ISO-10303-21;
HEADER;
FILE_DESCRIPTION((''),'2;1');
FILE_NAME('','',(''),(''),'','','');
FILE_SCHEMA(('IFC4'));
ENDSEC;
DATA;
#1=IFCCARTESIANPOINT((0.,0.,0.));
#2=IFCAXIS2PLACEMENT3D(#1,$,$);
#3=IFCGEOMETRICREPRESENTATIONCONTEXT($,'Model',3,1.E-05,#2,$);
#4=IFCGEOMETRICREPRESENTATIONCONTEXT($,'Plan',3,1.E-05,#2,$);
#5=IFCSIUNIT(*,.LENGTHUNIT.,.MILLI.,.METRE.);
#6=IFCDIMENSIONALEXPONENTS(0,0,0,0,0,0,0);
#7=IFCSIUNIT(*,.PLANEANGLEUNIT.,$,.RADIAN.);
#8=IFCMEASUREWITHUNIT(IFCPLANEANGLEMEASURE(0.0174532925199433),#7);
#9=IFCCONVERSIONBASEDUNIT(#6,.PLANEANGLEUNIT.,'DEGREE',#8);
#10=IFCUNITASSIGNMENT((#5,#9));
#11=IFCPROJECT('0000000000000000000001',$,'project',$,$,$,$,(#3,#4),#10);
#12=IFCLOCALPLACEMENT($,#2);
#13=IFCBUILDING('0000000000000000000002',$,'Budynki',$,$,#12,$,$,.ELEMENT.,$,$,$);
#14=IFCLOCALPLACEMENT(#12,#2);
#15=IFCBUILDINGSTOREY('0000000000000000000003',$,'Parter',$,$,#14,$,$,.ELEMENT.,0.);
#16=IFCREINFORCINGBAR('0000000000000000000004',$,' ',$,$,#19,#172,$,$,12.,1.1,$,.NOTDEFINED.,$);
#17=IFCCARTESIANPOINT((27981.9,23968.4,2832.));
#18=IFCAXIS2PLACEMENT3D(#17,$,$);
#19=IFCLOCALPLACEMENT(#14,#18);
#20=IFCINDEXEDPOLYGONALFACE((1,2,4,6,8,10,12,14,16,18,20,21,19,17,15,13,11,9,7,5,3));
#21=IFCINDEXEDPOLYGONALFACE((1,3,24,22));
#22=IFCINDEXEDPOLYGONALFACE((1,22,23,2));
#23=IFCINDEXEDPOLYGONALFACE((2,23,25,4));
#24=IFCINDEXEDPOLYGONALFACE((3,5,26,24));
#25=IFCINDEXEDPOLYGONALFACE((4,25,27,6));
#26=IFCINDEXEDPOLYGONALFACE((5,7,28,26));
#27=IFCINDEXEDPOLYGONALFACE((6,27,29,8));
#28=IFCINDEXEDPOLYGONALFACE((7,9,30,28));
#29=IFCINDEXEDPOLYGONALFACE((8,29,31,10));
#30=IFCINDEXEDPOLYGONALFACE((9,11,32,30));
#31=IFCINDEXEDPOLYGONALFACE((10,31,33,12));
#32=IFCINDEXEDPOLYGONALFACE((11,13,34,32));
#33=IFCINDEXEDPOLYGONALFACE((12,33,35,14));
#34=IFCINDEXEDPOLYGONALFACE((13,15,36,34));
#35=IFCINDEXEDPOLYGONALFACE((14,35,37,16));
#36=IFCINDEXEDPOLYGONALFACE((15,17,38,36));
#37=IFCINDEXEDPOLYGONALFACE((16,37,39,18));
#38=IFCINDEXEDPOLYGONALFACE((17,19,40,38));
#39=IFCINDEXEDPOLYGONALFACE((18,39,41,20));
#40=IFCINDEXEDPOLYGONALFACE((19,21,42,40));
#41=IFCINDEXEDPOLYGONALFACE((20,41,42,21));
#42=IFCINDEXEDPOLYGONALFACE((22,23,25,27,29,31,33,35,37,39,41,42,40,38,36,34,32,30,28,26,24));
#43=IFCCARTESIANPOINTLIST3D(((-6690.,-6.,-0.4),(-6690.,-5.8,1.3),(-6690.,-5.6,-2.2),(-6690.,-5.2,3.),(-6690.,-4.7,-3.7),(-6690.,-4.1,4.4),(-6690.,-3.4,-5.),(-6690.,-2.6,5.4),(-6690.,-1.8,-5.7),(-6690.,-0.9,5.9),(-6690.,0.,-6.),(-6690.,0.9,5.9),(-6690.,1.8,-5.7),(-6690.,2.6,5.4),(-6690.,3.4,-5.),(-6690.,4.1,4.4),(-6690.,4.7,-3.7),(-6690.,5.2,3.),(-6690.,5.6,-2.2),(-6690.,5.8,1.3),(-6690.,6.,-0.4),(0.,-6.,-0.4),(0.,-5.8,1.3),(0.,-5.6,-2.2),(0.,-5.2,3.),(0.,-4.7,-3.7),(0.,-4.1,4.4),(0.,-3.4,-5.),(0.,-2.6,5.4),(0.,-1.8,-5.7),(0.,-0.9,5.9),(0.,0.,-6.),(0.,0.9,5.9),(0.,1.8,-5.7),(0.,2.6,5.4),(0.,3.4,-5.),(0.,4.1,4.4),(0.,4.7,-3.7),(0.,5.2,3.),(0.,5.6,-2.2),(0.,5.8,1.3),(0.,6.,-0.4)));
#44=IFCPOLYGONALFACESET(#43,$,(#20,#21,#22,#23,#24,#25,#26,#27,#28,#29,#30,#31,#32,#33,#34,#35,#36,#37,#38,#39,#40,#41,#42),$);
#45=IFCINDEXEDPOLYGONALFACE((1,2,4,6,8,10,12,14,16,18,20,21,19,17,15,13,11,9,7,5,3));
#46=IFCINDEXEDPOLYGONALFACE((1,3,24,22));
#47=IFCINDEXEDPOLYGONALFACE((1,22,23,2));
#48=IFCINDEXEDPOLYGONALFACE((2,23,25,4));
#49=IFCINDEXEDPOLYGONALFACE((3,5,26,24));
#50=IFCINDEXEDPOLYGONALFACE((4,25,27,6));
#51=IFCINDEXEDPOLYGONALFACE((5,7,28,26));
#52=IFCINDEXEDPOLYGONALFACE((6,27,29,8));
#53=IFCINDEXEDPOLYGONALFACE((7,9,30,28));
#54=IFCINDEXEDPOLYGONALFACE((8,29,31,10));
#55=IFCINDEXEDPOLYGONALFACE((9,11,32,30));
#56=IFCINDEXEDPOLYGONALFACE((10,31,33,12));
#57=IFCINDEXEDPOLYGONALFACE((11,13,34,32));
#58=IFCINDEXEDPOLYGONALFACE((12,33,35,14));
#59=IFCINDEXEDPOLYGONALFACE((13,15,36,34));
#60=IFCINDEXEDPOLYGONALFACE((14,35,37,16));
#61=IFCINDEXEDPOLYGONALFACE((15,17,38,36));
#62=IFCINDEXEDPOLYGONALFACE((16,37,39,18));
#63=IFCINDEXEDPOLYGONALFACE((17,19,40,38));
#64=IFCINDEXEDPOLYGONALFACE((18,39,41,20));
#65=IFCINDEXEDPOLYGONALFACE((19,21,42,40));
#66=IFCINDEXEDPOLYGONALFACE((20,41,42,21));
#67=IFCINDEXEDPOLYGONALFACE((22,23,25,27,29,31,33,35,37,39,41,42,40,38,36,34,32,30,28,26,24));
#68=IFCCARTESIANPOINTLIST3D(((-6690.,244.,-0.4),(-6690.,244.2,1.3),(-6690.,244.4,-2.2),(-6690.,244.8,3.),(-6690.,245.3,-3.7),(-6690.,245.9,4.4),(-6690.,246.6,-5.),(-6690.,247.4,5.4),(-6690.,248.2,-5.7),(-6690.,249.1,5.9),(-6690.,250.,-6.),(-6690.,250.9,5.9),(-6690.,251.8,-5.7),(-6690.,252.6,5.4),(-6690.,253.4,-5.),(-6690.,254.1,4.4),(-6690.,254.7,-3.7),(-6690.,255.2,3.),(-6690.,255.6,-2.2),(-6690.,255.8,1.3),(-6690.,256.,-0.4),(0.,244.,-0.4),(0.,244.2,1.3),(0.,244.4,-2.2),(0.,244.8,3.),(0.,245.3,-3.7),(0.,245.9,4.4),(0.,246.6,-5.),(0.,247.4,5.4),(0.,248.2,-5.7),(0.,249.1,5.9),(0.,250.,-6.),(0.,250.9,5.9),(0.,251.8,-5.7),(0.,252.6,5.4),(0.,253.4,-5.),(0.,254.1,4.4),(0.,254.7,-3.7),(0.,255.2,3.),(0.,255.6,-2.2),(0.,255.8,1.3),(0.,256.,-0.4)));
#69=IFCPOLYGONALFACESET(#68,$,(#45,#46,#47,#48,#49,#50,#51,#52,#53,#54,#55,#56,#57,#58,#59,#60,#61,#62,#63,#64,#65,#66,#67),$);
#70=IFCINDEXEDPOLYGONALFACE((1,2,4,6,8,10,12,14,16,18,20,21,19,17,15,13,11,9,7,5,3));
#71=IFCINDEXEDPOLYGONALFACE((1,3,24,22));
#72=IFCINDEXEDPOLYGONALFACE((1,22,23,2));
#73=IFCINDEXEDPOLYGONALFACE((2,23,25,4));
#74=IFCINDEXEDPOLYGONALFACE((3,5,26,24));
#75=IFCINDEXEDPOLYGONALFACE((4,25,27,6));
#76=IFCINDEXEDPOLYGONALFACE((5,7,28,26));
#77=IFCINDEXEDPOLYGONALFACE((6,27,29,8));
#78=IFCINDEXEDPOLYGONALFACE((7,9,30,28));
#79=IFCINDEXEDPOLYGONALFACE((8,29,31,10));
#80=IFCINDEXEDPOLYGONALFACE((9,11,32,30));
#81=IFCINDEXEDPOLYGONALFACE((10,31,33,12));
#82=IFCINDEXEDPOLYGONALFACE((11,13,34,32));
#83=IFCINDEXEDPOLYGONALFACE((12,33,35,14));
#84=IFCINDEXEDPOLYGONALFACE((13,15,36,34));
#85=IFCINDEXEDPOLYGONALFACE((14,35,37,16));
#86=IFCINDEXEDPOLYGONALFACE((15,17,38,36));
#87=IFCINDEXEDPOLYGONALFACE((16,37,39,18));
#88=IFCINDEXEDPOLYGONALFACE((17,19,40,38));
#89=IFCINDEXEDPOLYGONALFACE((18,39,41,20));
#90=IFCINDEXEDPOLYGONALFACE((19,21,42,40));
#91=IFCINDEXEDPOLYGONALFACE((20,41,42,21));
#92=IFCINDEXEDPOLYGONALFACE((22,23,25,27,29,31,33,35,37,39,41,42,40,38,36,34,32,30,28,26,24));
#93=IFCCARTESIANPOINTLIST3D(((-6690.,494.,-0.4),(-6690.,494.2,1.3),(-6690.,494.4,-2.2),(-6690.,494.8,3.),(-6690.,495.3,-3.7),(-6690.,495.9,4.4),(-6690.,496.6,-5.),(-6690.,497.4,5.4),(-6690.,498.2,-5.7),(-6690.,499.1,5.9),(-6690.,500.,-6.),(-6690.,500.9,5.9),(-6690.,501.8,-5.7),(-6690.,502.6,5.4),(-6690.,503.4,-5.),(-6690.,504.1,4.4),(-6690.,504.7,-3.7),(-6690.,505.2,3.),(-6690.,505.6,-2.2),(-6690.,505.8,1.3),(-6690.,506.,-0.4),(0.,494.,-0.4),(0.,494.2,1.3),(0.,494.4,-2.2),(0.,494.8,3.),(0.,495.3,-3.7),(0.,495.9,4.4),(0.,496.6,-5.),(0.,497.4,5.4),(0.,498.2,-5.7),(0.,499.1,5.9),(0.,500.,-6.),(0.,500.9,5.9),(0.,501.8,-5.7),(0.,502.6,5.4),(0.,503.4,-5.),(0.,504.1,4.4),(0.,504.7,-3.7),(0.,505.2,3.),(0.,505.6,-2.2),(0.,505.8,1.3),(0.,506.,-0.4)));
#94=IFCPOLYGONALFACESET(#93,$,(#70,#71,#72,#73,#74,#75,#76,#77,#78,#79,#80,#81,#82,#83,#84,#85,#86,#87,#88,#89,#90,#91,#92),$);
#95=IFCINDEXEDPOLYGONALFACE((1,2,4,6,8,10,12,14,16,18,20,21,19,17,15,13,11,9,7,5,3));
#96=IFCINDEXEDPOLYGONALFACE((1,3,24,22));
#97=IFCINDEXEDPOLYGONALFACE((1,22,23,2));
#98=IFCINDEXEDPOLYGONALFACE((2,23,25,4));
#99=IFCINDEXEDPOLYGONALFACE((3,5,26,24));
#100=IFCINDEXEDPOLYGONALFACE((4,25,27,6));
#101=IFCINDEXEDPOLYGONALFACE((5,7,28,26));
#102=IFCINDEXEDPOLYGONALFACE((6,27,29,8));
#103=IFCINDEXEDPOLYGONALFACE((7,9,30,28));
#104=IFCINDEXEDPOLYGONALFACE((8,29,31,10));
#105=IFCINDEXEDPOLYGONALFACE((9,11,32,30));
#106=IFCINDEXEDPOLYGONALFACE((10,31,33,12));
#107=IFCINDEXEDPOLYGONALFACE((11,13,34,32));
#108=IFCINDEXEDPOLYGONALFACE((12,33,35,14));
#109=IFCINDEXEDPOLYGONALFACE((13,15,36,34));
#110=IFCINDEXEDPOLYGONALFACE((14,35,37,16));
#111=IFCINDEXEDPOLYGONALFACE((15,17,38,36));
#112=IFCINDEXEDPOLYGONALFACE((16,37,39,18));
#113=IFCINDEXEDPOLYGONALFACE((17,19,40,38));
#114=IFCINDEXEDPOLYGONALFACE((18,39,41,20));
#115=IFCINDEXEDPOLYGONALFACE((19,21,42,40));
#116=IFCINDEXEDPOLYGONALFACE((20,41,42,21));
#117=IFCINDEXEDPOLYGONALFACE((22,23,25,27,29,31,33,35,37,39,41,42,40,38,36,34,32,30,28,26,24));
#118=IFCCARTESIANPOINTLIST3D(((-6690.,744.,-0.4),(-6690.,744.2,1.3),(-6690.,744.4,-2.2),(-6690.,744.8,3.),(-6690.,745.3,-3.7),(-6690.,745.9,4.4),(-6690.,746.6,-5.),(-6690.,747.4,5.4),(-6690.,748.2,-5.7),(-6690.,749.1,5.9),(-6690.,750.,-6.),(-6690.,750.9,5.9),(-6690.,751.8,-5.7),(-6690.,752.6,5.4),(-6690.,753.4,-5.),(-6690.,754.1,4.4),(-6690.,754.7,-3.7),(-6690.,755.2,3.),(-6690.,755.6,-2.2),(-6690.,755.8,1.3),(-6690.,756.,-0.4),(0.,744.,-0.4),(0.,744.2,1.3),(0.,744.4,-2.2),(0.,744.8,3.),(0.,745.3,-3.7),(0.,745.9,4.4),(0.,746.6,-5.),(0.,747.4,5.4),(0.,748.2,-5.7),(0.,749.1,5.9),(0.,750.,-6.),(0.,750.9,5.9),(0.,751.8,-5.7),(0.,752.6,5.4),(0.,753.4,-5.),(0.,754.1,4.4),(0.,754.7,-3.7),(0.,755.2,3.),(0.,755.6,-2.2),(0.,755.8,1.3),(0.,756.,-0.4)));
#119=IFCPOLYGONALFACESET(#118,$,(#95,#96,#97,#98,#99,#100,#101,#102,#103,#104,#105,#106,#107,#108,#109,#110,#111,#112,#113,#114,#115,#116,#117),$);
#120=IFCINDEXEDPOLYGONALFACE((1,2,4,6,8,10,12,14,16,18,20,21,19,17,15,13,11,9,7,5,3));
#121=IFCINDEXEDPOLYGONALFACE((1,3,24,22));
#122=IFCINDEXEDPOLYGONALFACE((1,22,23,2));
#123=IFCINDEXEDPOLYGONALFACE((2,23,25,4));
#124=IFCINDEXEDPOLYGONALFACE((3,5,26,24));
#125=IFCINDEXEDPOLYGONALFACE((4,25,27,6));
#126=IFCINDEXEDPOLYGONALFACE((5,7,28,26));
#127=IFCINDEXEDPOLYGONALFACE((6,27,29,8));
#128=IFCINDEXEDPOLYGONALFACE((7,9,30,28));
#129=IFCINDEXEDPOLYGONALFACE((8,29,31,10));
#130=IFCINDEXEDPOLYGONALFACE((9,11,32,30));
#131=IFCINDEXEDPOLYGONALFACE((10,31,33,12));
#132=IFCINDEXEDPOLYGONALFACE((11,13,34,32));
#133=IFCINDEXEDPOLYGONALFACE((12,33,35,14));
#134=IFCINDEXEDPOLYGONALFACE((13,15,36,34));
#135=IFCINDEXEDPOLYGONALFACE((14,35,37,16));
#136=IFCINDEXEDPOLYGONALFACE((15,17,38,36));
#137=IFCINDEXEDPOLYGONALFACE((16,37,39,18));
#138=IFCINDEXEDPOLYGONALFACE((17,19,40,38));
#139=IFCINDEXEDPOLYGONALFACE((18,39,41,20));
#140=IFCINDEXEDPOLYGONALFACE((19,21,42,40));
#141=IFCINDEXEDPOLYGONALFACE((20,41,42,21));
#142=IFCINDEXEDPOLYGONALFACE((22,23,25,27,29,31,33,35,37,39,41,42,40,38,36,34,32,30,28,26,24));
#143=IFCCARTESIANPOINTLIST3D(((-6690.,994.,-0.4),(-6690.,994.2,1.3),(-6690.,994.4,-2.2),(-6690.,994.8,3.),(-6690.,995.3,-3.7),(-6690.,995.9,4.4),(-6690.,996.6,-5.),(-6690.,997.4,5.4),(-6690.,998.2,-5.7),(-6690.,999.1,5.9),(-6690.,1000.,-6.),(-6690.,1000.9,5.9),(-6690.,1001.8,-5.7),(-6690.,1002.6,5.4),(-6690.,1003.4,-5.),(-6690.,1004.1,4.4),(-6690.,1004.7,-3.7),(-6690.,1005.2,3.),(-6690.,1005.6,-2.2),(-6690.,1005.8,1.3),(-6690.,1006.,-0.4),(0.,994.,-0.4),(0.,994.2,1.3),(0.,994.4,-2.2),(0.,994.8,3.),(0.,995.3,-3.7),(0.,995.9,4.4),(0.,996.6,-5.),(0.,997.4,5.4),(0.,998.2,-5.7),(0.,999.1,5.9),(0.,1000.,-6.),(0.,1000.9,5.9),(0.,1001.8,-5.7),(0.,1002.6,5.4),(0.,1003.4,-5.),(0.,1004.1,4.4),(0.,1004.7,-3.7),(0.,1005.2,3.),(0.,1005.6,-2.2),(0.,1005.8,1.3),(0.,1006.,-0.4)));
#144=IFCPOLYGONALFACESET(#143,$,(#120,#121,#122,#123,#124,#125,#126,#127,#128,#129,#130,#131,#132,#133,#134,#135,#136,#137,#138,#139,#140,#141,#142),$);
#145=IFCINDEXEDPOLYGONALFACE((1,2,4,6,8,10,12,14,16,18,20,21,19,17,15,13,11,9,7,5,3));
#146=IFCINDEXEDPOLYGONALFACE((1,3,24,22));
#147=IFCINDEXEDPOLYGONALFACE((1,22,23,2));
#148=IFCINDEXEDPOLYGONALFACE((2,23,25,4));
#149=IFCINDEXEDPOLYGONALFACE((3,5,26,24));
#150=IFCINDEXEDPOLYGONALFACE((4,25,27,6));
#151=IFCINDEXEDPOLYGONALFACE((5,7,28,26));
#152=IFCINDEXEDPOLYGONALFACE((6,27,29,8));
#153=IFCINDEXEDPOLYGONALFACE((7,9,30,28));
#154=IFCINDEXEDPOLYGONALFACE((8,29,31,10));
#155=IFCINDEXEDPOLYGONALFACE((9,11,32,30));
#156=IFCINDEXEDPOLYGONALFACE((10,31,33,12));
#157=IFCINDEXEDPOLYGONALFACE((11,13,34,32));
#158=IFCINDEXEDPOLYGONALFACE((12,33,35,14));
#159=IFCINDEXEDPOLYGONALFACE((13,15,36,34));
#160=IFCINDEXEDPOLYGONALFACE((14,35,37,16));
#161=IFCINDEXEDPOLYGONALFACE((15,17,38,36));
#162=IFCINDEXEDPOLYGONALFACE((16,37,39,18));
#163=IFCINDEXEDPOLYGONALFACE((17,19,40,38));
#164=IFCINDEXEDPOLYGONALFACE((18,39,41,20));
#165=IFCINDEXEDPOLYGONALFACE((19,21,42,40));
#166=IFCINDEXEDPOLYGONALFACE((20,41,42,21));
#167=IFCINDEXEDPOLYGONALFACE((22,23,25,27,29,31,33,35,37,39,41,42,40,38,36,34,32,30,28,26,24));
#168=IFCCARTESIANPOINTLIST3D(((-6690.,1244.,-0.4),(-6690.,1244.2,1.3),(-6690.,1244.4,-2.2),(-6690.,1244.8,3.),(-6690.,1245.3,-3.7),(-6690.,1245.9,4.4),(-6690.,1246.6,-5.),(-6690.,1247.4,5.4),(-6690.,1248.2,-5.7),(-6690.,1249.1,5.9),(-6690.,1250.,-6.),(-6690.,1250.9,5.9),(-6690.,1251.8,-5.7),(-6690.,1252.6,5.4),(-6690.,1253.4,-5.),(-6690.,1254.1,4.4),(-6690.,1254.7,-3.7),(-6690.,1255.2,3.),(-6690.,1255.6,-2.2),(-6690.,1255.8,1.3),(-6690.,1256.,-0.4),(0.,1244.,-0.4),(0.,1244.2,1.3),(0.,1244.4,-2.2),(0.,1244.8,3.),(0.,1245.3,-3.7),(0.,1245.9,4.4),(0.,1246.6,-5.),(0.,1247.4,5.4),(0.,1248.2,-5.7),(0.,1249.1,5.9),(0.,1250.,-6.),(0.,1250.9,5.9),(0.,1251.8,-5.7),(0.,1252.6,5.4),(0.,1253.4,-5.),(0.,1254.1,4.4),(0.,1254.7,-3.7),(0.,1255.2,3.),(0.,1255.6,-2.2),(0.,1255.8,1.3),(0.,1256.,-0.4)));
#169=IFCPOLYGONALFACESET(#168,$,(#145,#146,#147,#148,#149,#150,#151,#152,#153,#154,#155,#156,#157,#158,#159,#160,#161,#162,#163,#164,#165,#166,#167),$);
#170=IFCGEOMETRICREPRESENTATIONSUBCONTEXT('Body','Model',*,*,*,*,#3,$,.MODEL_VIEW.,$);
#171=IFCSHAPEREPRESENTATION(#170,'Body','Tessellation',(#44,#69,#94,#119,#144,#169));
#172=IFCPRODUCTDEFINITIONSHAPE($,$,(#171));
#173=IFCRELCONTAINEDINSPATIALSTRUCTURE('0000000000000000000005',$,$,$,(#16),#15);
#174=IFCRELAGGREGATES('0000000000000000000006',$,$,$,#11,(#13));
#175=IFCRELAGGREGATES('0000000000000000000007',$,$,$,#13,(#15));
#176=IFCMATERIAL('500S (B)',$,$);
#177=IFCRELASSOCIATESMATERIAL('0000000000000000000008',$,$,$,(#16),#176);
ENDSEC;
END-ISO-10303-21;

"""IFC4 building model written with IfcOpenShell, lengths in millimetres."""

from ifc_helpers import new_model, entity, si_unit, converted_unit, frame, origin, place, context, subcontext, project, spatial, material, element, save


model = new_model("IFC4")

# Units and contexts
model_context = context("Model", 3, precision=1e-05, world=origin())
plan_context = context("Plan", 3, precision=1e-05, world=origin())
body_context = subcontext(model_context, "Body", "Model", "MODEL_VIEW")
ifc_project = project(units=[si_unit("LENGTHUNIT", "METRE", prefix="MILLI"), converted_unit("PLANEANGLEUNIT", "DEGREE", entity("IfcPlaneAngleMeasure", 0.0174532925199433), si_unit("PLANEANGLEUNIT", "RADIAN"), dimensions=[0, 0, 0, 0, 0, 0, 0])], contexts=[model_context, plan_context])

# Building, storey
building_placement = place(None, origin())
building = spatial("IfcBuilding", under=ifc_project, at=building_placement, Name="Budynki", CompositionType="ELEMENT")
storey_placement = place(building_placement, origin())
storey = spatial("IfcBuildingStorey", under=building, at=storey_placement, Name="Parter", CompositionType="ELEMENT", Elevation=0.0)

# Reinforcing bar
ifc_material_1 = material(Name="500S (B)")
reinforcing_bar_1_placement = place(storey_placement, frame((27981.9, 23968.4, 2832.0)))
element("IfcReinforcingBar", 1, at=reinforcing_bar_1_placement, inside=storey, material=ifc_material_1, Name=" ", CrossSectionArea=1.1, NominalDiameter=12.0, PredefinedType="NOTDEFINED", context=body_context, shape_type="AdvancedSweptSolid", body=[
    entity("IfcSweptDiskSolid", entity("IfcPolyline", [entity("IfcCartesianPoint", [0.0, 0.0, 0.0]), entity("IfcCartesianPoint", [-6690.0, 0.0, 0.0])]), 6.0, None, 0.0, 1.0),
    entity("IfcSweptDiskSolid", entity("IfcPolyline", [entity("IfcCartesianPoint", [0.0, 250.0, 0.0]), entity("IfcCartesianPoint", [-6690.0, 250.0, 0.0])]), 6.0, None, 0.0, 1.0),
    entity("IfcSweptDiskSolid", entity("IfcPolyline", [entity("IfcCartesianPoint", [0.0, 500.0, 0.0]), entity("IfcCartesianPoint", [-6690.0, 500.0, 0.0])]), 6.0, None, 0.0, 1.0),
    entity("IfcSweptDiskSolid", entity("IfcPolyline", [entity("IfcCartesianPoint", [0.0, 750.0, 0.0]), entity("IfcCartesianPoint", [-6690.0, 750.0, 0.0])]), 6.0, None, 0.0, 1.0),
    entity("IfcSweptDiskSolid", entity("IfcPolyline", [entity("IfcCartesianPoint", [0.0, 1000.0, 0.0]), entity("IfcCartesianPoint", [-6690.0, 1000.0, 0.0])]), 6.0, None, 0.0, 1.0),
    entity("IfcSweptDiskSolid", entity("IfcPolyline", [entity("IfcCartesianPoint", [0.0, 1250.0, 0.0]), entity("IfcCartesianPoint", [-6690.0, 1250.0, 0.0])]), 6.0, None, 0.0, 1.0),
])

save(model, "model.ifc")
